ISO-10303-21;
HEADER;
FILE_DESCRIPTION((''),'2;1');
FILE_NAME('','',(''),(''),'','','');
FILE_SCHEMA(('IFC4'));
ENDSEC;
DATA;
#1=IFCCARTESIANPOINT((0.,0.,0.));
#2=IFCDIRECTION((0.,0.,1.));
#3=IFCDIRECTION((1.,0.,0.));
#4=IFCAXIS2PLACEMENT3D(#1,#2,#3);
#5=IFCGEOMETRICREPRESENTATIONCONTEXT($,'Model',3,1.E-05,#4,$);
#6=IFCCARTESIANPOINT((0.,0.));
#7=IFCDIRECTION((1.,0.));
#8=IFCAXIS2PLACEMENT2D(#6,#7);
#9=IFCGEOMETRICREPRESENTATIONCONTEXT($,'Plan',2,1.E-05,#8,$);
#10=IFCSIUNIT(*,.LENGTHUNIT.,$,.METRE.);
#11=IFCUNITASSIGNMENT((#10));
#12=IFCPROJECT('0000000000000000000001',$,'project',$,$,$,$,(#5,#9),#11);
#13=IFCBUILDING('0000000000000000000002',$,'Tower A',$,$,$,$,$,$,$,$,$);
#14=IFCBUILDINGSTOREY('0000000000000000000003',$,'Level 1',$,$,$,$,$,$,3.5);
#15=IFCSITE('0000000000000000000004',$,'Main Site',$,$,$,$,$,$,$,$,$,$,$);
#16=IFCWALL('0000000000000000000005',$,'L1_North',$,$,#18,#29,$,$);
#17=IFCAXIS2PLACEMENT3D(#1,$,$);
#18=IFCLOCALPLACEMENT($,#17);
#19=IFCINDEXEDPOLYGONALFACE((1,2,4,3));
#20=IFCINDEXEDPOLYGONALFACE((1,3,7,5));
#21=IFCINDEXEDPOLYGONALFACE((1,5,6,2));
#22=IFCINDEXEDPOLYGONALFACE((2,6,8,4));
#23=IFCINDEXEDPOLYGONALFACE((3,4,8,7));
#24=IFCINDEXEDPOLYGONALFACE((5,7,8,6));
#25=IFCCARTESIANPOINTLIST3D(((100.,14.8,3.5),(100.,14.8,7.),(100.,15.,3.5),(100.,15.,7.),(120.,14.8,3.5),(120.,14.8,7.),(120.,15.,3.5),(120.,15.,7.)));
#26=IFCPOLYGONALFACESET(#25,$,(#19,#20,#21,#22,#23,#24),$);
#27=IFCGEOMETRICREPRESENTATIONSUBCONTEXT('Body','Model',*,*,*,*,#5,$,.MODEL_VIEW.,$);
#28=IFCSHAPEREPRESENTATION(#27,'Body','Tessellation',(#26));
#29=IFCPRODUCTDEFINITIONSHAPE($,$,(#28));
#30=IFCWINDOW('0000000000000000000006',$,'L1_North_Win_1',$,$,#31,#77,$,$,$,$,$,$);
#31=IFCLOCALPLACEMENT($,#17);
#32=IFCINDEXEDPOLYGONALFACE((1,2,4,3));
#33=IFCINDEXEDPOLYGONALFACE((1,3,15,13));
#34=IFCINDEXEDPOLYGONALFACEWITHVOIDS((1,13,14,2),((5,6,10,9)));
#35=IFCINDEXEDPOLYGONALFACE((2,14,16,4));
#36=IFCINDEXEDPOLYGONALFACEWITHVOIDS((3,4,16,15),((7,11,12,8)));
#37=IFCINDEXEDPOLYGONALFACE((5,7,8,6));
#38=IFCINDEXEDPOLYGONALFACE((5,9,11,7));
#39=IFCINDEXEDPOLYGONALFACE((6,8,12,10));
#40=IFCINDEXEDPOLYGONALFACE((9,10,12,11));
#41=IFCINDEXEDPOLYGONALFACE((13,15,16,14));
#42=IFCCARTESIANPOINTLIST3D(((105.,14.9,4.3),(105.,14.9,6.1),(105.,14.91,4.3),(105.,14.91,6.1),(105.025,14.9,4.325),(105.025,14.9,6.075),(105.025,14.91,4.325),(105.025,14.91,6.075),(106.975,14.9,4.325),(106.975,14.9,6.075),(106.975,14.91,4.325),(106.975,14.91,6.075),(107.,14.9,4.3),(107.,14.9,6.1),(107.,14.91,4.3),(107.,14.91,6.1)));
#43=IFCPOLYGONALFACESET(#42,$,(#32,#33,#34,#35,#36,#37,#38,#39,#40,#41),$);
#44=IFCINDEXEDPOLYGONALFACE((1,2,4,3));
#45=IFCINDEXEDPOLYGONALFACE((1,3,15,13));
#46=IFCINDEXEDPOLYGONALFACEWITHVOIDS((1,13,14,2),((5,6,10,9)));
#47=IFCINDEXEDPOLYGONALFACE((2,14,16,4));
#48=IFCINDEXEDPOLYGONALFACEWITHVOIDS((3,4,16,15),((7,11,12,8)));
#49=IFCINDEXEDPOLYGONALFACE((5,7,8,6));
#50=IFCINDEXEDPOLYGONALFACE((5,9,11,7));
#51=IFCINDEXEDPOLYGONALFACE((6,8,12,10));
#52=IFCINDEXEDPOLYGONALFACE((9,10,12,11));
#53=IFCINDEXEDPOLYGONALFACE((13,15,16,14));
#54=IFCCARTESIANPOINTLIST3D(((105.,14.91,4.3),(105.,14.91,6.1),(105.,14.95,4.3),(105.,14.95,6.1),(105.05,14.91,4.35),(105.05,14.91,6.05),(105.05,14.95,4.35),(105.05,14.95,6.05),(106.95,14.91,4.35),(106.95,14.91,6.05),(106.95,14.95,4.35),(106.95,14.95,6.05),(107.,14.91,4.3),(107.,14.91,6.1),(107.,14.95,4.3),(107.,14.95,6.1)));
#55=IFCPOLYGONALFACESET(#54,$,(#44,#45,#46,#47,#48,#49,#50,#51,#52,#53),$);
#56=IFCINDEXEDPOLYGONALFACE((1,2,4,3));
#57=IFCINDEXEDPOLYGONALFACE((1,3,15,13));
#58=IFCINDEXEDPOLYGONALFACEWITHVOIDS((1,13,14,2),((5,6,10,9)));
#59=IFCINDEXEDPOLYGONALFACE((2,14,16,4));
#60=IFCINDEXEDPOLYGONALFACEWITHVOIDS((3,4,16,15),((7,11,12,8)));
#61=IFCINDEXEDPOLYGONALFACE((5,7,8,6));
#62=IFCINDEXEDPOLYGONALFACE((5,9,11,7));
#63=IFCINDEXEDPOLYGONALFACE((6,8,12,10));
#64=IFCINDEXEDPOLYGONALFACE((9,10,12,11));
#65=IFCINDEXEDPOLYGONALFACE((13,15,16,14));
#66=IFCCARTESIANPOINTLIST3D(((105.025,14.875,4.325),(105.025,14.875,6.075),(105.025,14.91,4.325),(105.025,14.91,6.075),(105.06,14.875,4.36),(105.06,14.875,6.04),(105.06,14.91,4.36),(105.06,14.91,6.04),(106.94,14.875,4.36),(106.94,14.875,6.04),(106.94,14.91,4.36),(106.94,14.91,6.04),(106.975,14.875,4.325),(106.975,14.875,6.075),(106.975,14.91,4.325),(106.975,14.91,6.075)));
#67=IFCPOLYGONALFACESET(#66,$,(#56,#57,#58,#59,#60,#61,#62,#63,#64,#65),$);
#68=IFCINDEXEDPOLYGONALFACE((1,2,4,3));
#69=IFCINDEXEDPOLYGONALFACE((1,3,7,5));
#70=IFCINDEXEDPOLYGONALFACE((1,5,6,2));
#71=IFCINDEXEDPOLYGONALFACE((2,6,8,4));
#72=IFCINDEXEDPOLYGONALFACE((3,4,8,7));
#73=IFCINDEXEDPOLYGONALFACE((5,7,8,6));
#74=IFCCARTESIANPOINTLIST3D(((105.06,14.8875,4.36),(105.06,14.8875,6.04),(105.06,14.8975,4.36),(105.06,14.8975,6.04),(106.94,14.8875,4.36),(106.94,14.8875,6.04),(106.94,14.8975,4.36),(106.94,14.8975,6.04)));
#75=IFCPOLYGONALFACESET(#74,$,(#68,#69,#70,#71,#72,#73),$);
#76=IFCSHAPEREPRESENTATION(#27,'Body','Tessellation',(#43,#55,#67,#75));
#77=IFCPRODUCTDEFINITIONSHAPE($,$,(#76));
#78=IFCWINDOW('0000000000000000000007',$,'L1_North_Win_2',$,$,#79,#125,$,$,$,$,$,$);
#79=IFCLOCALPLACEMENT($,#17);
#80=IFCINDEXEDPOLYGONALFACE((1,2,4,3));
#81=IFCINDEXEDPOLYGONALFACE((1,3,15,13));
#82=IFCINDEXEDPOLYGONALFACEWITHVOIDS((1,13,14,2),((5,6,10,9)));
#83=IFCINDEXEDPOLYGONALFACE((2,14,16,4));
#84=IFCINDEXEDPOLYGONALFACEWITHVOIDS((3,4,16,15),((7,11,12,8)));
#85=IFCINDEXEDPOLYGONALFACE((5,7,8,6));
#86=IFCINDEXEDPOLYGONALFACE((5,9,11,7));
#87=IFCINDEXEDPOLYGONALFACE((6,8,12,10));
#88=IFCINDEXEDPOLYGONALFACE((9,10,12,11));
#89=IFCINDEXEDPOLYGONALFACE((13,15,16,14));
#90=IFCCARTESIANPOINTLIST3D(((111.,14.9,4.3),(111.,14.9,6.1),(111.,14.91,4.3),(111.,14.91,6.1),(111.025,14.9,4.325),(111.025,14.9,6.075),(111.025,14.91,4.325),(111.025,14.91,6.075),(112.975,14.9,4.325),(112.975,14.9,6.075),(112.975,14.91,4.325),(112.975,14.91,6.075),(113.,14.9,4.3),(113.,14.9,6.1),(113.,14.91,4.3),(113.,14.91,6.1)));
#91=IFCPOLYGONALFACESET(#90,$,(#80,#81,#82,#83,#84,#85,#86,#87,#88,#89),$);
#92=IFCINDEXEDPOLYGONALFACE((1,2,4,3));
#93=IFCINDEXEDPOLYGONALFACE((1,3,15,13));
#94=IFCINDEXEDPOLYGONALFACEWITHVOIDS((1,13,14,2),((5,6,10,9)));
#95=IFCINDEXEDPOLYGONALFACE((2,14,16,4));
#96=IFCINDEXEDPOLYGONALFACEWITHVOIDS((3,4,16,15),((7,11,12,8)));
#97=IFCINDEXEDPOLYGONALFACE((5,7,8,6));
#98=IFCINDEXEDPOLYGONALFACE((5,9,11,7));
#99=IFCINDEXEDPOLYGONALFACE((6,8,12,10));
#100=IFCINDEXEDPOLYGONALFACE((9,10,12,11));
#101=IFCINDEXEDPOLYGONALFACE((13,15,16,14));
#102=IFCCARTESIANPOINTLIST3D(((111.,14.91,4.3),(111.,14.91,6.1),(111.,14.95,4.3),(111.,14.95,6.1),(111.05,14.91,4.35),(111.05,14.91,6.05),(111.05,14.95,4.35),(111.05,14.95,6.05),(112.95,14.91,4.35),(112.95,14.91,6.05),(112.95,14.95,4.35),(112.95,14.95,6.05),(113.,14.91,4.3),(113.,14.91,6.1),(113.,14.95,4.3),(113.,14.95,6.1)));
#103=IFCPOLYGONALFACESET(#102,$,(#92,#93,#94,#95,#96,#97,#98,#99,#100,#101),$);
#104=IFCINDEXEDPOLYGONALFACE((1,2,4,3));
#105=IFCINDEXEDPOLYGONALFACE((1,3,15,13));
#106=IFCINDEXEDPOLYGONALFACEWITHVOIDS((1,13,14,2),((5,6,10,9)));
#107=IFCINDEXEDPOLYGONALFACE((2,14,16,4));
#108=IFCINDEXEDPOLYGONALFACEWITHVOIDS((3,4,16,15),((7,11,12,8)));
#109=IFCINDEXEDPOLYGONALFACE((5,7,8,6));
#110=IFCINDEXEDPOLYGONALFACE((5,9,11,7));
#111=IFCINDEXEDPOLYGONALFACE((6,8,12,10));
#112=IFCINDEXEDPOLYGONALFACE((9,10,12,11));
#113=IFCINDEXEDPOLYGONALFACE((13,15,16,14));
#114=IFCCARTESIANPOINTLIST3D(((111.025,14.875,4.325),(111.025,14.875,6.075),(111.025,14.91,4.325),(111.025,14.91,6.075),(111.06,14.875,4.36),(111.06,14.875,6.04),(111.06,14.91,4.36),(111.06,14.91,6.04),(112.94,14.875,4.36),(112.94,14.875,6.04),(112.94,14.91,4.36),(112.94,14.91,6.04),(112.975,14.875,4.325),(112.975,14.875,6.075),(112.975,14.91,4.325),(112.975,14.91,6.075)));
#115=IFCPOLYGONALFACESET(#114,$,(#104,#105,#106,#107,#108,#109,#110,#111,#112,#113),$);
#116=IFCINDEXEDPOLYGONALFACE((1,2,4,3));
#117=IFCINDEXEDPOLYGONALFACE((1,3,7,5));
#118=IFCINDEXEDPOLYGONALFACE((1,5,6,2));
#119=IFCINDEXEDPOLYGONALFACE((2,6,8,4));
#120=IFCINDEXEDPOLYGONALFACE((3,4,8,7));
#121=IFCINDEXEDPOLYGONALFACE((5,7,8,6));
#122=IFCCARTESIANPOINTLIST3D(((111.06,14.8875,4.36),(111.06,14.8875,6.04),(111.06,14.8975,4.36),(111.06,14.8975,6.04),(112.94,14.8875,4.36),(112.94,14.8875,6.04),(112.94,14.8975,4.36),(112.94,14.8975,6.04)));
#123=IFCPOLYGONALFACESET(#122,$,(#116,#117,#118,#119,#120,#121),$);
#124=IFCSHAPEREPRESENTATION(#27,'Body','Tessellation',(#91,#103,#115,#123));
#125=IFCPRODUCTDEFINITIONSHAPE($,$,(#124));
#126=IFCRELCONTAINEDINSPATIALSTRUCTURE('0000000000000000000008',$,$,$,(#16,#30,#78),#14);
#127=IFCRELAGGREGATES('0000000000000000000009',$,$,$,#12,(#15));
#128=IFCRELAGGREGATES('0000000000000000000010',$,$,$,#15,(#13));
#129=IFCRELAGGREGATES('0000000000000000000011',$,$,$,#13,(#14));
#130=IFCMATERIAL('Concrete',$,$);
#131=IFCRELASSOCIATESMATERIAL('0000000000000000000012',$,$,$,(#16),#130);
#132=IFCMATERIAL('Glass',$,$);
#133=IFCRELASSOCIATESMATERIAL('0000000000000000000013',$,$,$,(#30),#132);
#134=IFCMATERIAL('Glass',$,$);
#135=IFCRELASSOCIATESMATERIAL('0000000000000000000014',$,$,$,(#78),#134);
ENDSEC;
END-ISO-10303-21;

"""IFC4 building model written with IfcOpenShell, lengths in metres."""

from ifc_helpers import new_model, si_unit, frame, origin_with_axes, origin_2d_with_axis, place, context, subcontext, project, spatial, line, indexed_curve, outline, extrude, material, element, fill, save


model = new_model("IFC4")

# Units and contexts
model_context = context("Model", 3, precision=1e-05, world=origin_with_axes())
plan_context = context("Plan", 2, precision=1e-05, world=origin_2d_with_axis())
body_context = subcontext(model_context, "Body", "Model", "MODEL_VIEW")
ifc_project = project(units=[si_unit("LENGTHUNIT", "METRE")], contexts=[model_context, plan_context])

# Site, building, storey
site = spatial("IfcSite", under=ifc_project, Name="Main Site")
building = spatial("IfcBuilding", under=site, Name="Tower A")
storey = spatial("IfcBuildingStorey", under=building, Name="Level 1", Elevation=3.5)

# Wall, openings, windows
ifc_material_1 = material(Name="Concrete")
wall_1_placement = place(None, frame((120.0, 15.0, 3.5), z_axis=(0.0, 0.0, 1.0), x_axis=(-1.0, 0.0, 0.0)))
wall_1 = element("IfcWall", 1, at=wall_1_placement, inside=storey, material=ifc_material_1, Name="L1_North", context=body_context, shape_type="SweptSolid", body=[
    extrude(outline(indexed_curve([(0.0, 0.0), (0.0, 0.2), (20.0, 0.2), (20.0, 0.0), (0.0, 0.0)], self_intersect=False)), origin_with_axes(), (0.0, 0.0, 1.0), 3.5),
])
opening_1_placement = place(wall_1_placement, frame((13.0, 0.0, 0.8), z_axis=(0.0, 0.0, 1.0), x_axis=(-1.0, 0.0, 0.0)))
opening_1 = element("IfcOpeningElement", 2, at=opening_1_placement, cuts=wall_1, context=body_context, shape_type="SweptSolid", body=[
    extrude(outline(indexed_curve([(0.0, 0.0), (0.0, 0.25), (2.0, 0.25), (2.0, 0.0), (0.0, 0.0)], self_intersect=False)), origin_with_axes(), (0.0, 0.0, 1.0), 1.8),
])
opening_2_placement = place(wall_1_placement, frame((7.0, 0.0, 0.8), z_axis=(0.0, 0.0, 1.0), x_axis=(-1.0, 0.0, 0.0)))
opening_2 = element("IfcOpeningElement", 3, at=opening_2_placement, cuts=wall_1, context=body_context, shape_type="SweptSolid", body=[
    extrude(outline(indexed_curve([(0.0, 0.0), (0.0, 0.25), (2.0, 0.25), (2.0, 0.0), (0.0, 0.0)], self_intersect=False)), origin_with_axes(), (0.0, 0.0, 1.0), 1.8),
])
ifc_material_2 = material(Name="Glass")
window_1_placement = place(None, frame((107.0, 15.0, 4.3), z_axis=(0.0, 0.0, 1.0), x_axis=(-1.0, 0.0, 0.0)))
window_1 = element("IfcWindow", 4, at=window_1_placement, inside=storey, material=ifc_material_2, Name="L1_North_Win_1", context=body_context, shape_type="SweptSolid", body=[
    extrude(outline(indexed_curve([(0.0, 0.0), (2.0, 0.0), (2.0, 1.8), (0.0, 1.8)], segments=[line(1, 2, 3, 4, 1)]), holes=[indexed_curve([(0.025, 0.025), (1.975, 0.025), (1.975, 1.775), (0.025, 1.775)], segments=[line(1, 2, 3, 4, 1)])]), frame((0.0, 0.09, 0.0), z_axis=(0.0, -1.0, 0.0), x_axis=(1.0, 0.0, 0.0)), (0.0, 0.0, -1.0), 0.01),
    extrude(outline(indexed_curve([(0.0, 0.0), (2.0, 0.0), (2.0, 1.8), (0.0, 1.8)], segments=[line(1, 2, 3, 4, 1)]), holes=[indexed_curve([(0.05, 0.05), (1.95, 0.05), (1.95, 1.75), (0.05, 1.75)], segments=[line(1, 2, 3, 4, 1)])]), frame((0.0, 0.05, 0.0), z_axis=(0.0, -1.0, 0.0), x_axis=(1.0, 0.0, 0.0)), (0.0, 0.0, -1.0), 0.04),
    extrude(outline(indexed_curve([(0.0, 0.0), (1.95, 0.0), (1.95, 1.75), (0.0, 1.75)], segments=[line(1, 2, 3, 4, 1)]), holes=[indexed_curve([(0.035, 0.035), (1.915, 0.035), (1.915, 1.715), (0.035, 1.715)], segments=[line(1, 2, 3, 4, 1)])]), frame((0.025, 0.09, 0.025), z_axis=(0.0, -1.0, 0.0), x_axis=(1.0, 0.0, 0.0)), (0.0, 0.0, -1.0), 0.035),
    extrude(outline(indexed_curve([(0.035, 0.035), (1.915, 0.035), (1.915, 1.715), (0.035, 1.715)], segments=[line(1, 2, 3, 4, 1)])), frame((0.025, 0.1025, 0.025), z_axis=(0.0, -1.0, 0.0), x_axis=(1.0, 0.0, 0.0)), (0.0, 0.0, -1.0), 0.01),
])
fill(opening_1, window_1)
ifc_material_3 = material(Name="Glass")
window_2_placement = place(None, frame((113.0, 15.0, 4.3), z_axis=(0.0, 0.0, 1.0), x_axis=(-1.0, 0.0, 0.0)))
window_2 = element("IfcWindow", 5, at=window_2_placement, inside=storey, material=ifc_material_3, Name="L1_North_Win_2", context=body_context, shape_type="SweptSolid", body=[
    extrude(outline(indexed_curve([(0.0, 0.0), (2.0, 0.0), (2.0, 1.8), (0.0, 1.8)], segments=[line(1, 2, 3, 4, 1)]), holes=[indexed_curve([(0.025, 0.025), (1.975, 0.025), (1.975, 1.775), (0.025, 1.775)], segments=[line(1, 2, 3, 4, 1)])]), frame((0.0, 0.09, 0.0), z_axis=(0.0, -1.0, 0.0), x_axis=(1.0, 0.0, 0.0)), (0.0, 0.0, -1.0), 0.01),
    extrude(outline(indexed_curve([(0.0, 0.0), (2.0, 0.0), (2.0, 1.8), (0.0, 1.8)], segments=[line(1, 2, 3, 4, 1)]), holes=[indexed_curve([(0.05, 0.05), (1.95, 0.05), (1.95, 1.75), (0.05, 1.75)], segments=[line(1, 2, 3, 4, 1)])]), frame((0.0, 0.05, 0.0), z_axis=(0.0, -1.0, 0.0), x_axis=(1.0, 0.0, 0.0)), (0.0, 0.0, -1.0), 0.04),
    extrude(outline(indexed_curve([(0.0, 0.0), (1.95, 0.0), (1.95, 1.75), (0.0, 1.75)], segments=[line(1, 2, 3, 4, 1)]), holes=[indexed_curve([(0.035, 0.035), (1.915, 0.035), (1.915, 1.715), (0.035, 1.715)], segments=[line(1, 2, 3, 4, 1)])]), frame((0.025, 0.09, 0.025), z_axis=(0.0, -1.0, 0.0), x_axis=(1.0, 0.0, 0.0)), (0.0, 0.0, -1.0), 0.035),
    extrude(outline(indexed_curve([(0.035, 0.035), (1.915, 0.035), (1.915, 1.715), (0.035, 1.715)], segments=[line(1, 2, 3, 4, 1)])), frame((0.025, 0.1025, 0.025), z_axis=(0.0, -1.0, 0.0), x_axis=(1.0, 0.0, 0.0)), (0.0, 0.0, -1.0), 0.01),
])
fill(opening_2, window_2)

save(model, "model.ifc")
